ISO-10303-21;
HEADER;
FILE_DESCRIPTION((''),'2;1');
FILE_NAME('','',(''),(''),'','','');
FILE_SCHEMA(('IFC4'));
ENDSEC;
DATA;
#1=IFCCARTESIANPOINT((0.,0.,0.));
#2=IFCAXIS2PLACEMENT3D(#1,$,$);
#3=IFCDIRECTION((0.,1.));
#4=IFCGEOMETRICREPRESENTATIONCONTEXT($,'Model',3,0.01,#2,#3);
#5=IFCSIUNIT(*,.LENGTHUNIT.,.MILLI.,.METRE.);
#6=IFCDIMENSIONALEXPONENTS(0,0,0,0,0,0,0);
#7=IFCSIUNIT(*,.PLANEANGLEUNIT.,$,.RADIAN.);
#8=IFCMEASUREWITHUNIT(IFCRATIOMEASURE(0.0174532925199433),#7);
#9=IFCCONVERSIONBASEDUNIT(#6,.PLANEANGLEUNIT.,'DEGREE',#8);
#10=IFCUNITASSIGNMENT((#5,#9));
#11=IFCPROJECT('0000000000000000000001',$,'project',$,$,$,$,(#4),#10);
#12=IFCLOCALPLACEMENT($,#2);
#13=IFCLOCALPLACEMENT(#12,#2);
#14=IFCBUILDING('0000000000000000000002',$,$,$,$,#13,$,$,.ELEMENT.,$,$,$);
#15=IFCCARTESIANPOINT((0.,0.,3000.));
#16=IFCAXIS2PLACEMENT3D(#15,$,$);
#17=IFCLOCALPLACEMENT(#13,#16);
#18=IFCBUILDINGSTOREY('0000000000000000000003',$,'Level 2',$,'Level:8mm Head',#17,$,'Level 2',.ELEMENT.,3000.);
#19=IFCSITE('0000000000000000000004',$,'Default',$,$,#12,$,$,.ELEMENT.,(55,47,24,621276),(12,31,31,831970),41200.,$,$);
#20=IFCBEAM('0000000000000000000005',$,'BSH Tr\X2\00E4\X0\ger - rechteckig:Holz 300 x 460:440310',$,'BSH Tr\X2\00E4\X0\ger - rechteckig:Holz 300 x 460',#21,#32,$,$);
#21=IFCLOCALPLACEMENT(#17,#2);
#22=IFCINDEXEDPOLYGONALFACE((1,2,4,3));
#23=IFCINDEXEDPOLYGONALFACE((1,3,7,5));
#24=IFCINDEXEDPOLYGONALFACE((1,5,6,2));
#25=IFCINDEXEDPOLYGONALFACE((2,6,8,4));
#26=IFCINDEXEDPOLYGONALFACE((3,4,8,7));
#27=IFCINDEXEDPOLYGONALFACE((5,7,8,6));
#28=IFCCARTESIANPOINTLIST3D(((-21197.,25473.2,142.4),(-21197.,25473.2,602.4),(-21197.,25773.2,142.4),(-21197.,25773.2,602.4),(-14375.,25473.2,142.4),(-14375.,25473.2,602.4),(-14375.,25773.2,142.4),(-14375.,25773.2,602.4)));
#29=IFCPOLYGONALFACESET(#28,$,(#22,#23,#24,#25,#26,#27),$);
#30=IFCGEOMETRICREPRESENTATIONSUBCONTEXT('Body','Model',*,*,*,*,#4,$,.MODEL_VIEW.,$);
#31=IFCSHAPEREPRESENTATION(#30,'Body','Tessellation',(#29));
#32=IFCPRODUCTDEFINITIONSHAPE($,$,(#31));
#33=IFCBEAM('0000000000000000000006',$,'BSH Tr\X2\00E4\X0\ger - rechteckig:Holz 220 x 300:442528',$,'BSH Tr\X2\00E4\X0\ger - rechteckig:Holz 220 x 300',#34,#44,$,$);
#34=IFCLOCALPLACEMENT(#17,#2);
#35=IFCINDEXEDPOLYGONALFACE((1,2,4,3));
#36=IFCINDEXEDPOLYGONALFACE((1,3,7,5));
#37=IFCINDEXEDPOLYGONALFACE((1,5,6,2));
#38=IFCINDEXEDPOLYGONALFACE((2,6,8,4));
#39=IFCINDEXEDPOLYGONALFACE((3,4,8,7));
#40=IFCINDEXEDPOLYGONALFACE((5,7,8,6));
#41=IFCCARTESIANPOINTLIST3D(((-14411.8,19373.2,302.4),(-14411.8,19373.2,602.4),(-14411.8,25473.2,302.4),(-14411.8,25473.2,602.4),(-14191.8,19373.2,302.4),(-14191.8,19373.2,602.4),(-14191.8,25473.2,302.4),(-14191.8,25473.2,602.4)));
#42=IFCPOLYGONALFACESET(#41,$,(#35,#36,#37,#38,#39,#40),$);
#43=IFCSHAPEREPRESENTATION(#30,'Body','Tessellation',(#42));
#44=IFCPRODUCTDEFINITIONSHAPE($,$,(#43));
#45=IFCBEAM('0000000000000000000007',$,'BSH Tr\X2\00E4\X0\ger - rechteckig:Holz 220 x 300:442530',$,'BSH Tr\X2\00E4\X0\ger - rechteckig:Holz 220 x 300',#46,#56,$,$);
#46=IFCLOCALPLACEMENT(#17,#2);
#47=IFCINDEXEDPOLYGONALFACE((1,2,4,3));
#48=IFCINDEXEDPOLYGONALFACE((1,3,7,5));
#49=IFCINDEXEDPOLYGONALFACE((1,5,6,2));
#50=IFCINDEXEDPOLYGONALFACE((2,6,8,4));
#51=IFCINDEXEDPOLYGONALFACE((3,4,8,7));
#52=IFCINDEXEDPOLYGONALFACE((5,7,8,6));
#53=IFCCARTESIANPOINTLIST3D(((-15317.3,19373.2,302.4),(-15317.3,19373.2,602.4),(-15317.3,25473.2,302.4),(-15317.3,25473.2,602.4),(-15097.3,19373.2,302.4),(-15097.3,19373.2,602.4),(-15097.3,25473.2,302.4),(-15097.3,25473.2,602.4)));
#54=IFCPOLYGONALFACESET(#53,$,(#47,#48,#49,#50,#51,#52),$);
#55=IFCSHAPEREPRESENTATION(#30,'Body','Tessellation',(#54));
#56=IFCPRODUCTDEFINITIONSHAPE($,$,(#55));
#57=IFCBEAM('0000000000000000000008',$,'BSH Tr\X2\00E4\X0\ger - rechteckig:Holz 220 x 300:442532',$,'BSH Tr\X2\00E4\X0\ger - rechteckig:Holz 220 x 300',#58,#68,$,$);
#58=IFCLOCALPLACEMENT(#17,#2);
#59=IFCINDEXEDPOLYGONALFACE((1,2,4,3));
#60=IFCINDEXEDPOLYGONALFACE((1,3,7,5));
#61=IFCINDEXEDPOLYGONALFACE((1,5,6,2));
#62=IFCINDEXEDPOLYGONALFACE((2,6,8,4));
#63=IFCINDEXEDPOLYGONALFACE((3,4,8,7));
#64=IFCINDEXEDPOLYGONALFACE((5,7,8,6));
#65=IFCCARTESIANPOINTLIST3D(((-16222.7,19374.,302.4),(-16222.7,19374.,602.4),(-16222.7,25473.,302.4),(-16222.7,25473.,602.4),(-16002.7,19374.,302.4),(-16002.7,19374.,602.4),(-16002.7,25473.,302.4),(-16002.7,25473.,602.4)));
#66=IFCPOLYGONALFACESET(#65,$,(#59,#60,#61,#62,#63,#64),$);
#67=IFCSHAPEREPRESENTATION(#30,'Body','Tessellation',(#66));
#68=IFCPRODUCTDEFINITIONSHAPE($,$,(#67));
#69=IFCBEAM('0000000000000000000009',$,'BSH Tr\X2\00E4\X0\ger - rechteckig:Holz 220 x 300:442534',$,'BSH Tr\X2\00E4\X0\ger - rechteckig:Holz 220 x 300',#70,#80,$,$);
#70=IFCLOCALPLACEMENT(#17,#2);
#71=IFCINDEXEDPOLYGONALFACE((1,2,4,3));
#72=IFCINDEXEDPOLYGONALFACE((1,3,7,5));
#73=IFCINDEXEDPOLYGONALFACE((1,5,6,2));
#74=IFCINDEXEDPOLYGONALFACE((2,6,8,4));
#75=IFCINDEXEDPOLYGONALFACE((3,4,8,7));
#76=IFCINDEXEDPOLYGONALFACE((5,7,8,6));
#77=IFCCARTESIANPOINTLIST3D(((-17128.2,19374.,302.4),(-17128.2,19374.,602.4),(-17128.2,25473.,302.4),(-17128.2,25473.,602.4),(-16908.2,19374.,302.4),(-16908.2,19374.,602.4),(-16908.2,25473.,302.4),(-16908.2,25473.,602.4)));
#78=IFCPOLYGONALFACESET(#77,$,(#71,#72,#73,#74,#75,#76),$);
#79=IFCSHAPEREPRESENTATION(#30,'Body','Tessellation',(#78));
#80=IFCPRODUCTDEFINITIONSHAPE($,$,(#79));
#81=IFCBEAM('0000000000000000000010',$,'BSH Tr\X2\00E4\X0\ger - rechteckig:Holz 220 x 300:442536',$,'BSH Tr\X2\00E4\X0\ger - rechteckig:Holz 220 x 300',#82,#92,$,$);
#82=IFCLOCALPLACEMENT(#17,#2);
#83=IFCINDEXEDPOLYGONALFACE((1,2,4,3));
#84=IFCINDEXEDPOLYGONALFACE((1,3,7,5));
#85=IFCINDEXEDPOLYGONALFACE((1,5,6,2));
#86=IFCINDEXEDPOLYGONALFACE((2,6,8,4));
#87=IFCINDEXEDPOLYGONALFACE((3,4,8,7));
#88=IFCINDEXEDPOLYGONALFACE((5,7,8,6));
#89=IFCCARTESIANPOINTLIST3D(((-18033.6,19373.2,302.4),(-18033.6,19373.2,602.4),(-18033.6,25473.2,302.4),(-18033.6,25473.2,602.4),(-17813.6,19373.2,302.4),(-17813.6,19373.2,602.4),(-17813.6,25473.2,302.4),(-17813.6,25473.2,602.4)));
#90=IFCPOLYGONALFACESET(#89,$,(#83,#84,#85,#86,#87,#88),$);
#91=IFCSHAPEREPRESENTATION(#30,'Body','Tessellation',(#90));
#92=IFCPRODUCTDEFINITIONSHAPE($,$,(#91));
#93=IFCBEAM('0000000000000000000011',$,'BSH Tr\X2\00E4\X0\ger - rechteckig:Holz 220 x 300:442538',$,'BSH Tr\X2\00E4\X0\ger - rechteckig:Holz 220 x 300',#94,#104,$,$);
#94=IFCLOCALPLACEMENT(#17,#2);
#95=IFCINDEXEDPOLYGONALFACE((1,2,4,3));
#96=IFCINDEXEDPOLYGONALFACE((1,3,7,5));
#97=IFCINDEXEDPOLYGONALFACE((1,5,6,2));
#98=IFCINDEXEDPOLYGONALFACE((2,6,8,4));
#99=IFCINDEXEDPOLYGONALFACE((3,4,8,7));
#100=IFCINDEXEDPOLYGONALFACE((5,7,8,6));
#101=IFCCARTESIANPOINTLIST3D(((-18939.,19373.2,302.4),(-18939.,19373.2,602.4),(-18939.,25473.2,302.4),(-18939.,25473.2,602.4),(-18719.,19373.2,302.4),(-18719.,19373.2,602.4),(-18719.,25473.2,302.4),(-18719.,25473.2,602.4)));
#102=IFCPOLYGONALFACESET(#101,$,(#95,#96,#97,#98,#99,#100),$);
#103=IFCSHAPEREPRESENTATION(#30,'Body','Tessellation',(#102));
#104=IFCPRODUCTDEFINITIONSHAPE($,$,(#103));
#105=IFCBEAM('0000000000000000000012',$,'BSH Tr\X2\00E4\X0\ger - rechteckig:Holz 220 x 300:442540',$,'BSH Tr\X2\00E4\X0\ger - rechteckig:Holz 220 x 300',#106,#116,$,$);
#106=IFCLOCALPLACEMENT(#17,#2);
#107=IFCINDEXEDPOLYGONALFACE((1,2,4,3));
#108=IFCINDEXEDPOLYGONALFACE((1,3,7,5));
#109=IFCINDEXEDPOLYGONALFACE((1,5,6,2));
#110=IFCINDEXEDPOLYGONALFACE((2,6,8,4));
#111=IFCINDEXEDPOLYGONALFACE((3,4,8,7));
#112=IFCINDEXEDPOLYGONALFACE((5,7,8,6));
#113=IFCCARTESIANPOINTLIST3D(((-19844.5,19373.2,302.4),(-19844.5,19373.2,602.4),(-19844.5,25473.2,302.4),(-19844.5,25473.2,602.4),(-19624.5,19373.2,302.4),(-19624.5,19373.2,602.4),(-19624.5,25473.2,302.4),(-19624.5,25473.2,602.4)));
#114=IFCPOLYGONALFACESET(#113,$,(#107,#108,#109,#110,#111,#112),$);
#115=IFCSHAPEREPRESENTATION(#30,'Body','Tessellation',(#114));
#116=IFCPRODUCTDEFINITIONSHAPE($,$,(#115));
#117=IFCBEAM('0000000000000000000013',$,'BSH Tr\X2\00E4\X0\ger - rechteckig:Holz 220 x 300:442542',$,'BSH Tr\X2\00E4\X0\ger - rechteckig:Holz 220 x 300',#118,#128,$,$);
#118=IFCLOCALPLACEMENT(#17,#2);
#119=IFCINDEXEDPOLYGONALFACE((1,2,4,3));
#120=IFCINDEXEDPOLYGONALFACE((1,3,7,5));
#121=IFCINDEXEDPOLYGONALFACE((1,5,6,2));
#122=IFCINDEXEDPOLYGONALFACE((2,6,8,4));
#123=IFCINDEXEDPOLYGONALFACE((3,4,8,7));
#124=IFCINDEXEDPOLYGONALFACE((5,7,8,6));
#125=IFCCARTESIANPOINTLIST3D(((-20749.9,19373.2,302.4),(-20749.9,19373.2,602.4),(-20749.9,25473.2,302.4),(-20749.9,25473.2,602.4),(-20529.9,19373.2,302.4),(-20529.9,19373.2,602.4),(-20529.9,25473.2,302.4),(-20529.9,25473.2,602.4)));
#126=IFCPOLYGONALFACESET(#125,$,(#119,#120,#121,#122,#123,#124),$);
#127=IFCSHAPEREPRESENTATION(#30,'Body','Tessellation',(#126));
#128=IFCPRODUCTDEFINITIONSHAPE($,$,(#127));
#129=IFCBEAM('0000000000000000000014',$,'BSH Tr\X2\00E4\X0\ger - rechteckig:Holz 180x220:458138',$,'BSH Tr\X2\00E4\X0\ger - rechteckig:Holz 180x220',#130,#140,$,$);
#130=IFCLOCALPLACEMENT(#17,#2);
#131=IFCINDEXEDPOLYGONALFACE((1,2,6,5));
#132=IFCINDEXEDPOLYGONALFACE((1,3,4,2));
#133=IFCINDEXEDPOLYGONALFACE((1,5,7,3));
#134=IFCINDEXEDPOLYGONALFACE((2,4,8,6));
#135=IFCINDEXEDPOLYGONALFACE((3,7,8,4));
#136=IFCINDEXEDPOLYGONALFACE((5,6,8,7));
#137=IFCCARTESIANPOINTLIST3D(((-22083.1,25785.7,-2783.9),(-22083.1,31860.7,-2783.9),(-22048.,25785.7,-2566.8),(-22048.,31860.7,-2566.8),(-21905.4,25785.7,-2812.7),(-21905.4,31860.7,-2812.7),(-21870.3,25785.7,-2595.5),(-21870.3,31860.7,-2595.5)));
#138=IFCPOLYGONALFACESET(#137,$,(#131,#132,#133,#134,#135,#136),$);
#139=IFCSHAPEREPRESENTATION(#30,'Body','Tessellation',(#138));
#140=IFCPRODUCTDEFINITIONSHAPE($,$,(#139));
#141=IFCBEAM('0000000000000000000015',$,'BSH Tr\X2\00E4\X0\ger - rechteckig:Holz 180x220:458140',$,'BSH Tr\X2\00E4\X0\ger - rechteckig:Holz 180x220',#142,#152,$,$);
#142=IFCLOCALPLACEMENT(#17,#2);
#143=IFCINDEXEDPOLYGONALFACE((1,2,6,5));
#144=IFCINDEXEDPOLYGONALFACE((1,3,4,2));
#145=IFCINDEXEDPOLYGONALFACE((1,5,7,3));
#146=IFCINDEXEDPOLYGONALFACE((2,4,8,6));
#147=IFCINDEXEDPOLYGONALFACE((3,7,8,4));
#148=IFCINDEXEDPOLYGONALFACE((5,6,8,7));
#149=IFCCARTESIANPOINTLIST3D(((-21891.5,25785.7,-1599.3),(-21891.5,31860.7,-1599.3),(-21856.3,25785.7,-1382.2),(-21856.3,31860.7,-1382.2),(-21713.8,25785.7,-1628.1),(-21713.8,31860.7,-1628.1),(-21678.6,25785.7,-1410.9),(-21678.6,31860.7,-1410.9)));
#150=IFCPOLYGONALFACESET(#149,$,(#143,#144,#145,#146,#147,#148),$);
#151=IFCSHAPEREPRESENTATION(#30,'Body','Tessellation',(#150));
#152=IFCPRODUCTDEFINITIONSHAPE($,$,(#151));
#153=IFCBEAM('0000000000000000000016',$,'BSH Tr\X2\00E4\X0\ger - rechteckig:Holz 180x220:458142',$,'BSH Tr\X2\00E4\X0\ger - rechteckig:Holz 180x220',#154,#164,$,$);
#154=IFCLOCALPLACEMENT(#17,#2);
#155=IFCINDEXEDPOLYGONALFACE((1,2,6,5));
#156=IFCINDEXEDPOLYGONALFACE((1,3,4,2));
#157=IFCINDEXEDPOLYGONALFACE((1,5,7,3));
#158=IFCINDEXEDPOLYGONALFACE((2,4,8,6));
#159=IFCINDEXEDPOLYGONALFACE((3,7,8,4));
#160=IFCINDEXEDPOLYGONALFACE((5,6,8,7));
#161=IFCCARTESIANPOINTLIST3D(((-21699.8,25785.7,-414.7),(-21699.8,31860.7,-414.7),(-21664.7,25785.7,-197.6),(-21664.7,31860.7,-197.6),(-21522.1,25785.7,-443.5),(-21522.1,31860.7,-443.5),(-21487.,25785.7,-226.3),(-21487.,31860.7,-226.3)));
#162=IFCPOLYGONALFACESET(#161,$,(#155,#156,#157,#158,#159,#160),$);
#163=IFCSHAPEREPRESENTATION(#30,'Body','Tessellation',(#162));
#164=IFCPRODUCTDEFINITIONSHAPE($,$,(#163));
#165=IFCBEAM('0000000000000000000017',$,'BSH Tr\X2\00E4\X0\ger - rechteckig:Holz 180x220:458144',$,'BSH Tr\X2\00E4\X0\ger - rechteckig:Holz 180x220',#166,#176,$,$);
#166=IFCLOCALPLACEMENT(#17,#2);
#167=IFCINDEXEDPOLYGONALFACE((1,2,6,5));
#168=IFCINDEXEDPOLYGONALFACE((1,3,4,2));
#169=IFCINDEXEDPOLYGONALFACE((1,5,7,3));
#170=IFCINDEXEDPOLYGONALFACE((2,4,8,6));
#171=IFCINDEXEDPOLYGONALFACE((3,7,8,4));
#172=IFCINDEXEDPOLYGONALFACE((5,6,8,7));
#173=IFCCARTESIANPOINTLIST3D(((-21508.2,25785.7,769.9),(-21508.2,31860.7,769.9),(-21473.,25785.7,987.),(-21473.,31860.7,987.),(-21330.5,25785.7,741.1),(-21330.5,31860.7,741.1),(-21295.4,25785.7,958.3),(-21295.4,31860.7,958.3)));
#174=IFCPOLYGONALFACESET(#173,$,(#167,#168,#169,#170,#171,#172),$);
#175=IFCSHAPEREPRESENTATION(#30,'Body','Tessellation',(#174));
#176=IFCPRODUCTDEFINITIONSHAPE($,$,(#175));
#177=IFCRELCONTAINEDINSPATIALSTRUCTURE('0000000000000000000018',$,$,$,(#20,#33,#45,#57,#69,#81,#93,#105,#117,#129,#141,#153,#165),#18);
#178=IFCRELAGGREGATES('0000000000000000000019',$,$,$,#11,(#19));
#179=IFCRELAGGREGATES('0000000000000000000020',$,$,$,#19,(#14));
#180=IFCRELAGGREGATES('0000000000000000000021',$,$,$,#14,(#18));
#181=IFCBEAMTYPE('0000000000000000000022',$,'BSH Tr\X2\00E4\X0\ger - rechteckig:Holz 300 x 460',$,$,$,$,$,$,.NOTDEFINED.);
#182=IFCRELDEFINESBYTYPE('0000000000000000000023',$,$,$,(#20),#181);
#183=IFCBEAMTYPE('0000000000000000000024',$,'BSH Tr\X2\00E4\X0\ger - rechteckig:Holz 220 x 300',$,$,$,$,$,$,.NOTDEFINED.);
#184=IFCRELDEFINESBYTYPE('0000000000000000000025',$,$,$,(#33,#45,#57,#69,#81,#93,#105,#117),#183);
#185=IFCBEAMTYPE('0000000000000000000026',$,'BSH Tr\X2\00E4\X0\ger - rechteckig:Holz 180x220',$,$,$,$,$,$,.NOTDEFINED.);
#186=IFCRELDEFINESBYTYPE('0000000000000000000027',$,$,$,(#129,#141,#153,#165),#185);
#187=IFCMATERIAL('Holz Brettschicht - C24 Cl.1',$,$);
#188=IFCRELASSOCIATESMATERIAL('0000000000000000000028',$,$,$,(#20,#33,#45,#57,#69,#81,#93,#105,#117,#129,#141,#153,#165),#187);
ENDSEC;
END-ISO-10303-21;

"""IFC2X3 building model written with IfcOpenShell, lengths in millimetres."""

from ifc_helpers import new_model, entity, si_unit, converted_unit, direction, frame, frame_2d, origin, origin_2d_with_axis, place, context, subcontext, project, spatial, rectangle, extrude, material, type_object, element, save


model = new_model("IFC2X3")

# Units and contexts
model_context = context("Model", 3, precision=0.01, world=origin(), true_north=direction((0.0, 1.0)))
body_context = subcontext(model_context, "Body", "Model", "MODEL_VIEW")
ifc_project = project(units=[si_unit("LENGTHUNIT", "METRE", prefix="MILLI"), converted_unit("PLANEANGLEUNIT", "DEGREE", entity("IfcRatioMeasure", 0.0174532925199433), si_unit("PLANEANGLEUNIT", "RADIAN"), dimensions=[0, 0, 0, 0, 0, 0, 0])], contexts=[model_context])

# Site, building, storey
site_placement = place(None, origin())
site = spatial("IfcSite", under=ifc_project, at=site_placement, Name="Default", CompositionType="ELEMENT", RefLatitude=(55, 47, 24, 621276), RefLongitude=(12, 31, 31, 831970), RefElevation=41200.0)
building_placement = place(site_placement, origin())
building = spatial("IfcBuilding", under=site, at=building_placement, CompositionType="ELEMENT")
storey_placement = place(building_placement, frame((0.0, 0.0, 3000.0)))
storey = spatial("IfcBuildingStorey", under=building, at=storey_placement, Name="Level 2", ObjectType="Level:8mm Head", LongName="Level 2", CompositionType="ELEMENT", Elevation=3000.0)

# Beams
ifc_material_1 = material(Name="Holz Brettschicht - C24 Cl.1")
beam_type_1 = type_object("IfcBeamType", Name="BSH Träger - rechteckig:Holz 300 x 460", PredefinedType="NOTDEFINED")
beam_1_placement = place(storey_placement, frame((-14041.8, 25623.2, 602.4), z_axis=(0.0, 0.0, 1.0), x_axis=(-1.0, 0.0, 0.0)))
element("IfcBeam", 1, at=beam_1_placement, inside=storey, type_object=beam_type_1, material=ifc_material_1, Name="BSH Träger - rechteckig:Holz 300 x 460:440310", ObjectType="BSH Träger - rechteckig:Holz 300 x 460", context=body_context, shape_type="SweptSolid", body=[
    extrude(rectangle(XDim=460.0, YDim=300.0, at=frame_2d((0.0, 0.0), x_axis=(1.0, 0.0))), frame((333.2, 0.0, -230.0), z_axis=(1.0, 0.0, 0.0), x_axis=(0.0, 0.0, -1.0)), (0.0, 0.0, 1.0), 6822.0),
])
beam_type_2 = type_object("IfcBeamType", Name="BSH Träger - rechteckig:Holz 220 x 300", PredefinedType="NOTDEFINED")
for number, where, z_axis, x_axis, name in (
    (2, (-14301.8, 25623.2, 602.4), (0.0, 0.0, 1.0), (0.0, -1.0, 0.0), "BSH Träger - rechteckig:Holz 220 x 300:442528"),
    (3, (-15207.3, 25623.2, 602.4), (0.0, 0.0, 1.0), (0.0, -1.0, 0.0), "BSH Träger - rechteckig:Holz 220 x 300:442530"),
):
    element("IfcBeam", number, at=place(storey_placement, frame(where, z_axis=z_axis, x_axis=x_axis)), inside=storey, type_object=beam_type_2, material=ifc_material_1, Name=name, ObjectType="BSH Träger - rechteckig:Holz 220 x 300", context=body_context, shape_type="SweptSolid", body=[
        extrude(rectangle(XDim=300.0, YDim=220.0, at=frame_2d((0.0, 0.0), x_axis=(1.0, 0.0))), frame((150.0, 0.0, -150.0), z_axis=(1.0, 0.0, 0.0), x_axis=(0.0, 0.0, -1.0)), (0.0, 0.0, 1.0), 6100.0),
    ])
for number, where, z_axis, x_axis, name in (
    (4, (-16112.7, 25536.0, 602.4), (0.0, 0.0, 1.0), (0.0, -1.0, 0.0), "BSH Träger - rechteckig:Holz 220 x 300:442532"),
    (5, (-17018.2, 25536.0, 602.4), (0.0, 0.0, 1.0), (0.0, -1.0, 0.0), "BSH Träger - rechteckig:Holz 220 x 300:442534"),
):
    element("IfcBeam", number, at=place(storey_placement, frame(where, z_axis=z_axis, x_axis=x_axis)), inside=storey, type_object=beam_type_2, material=ifc_material_1, Name=name, ObjectType="BSH Träger - rechteckig:Holz 220 x 300", context=body_context, shape_type="SweptSolid", body=[
        extrude(rectangle(XDim=300.0, YDim=220.0, at=frame_2d((0.0, 0.0), x_axis=(1.0, 0.0))), frame((63.0, 0.0, -150.0), z_axis=(1.0, 0.0, 0.0), x_axis=(0.0, 0.0, -1.0)), (0.0, 0.0, 1.0), 6099.0),
    ])
for number, where, z_axis, x_axis, name in (
    (6, (-17923.6, 25623.2, 602.4), (0.0, 0.0, 1.0), (0.0, -1.0, 0.0), "BSH Träger - rechteckig:Holz 220 x 300:442536"),
    (7, (-18829.0, 25623.2, 602.4), (0.0, 0.0, 1.0), (0.0, -1.0, 0.0), "BSH Träger - rechteckig:Holz 220 x 300:442538"),
):
    element("IfcBeam", number, at=place(storey_placement, frame(where, z_axis=z_axis, x_axis=x_axis)), inside=storey, type_object=beam_type_2, material=ifc_material_1, Name=name, ObjectType="BSH Träger - rechteckig:Holz 220 x 300", context=body_context, shape_type="SweptSolid", body=[
        extrude(rectangle(XDim=300.0, YDim=220.0, at=frame_2d((0.0, 0.0), x_axis=(1.0, 0.0))), frame((150.0, 0.0, -150.0), z_axis=(1.0, 0.0, 0.0), x_axis=(0.0, 0.0, -1.0)), (0.0, 0.0, 1.0), 6100.0),
    ])
for number, where, z_axis, x_axis, name in (
    (8, (-19734.5, 25623.2, 602.4), (0.0, 0.0, 1.0), (0.0, -1.0, 0.0), "BSH Träger - rechteckig:Holz 220 x 300:442540"),
    (9, (-20639.9, 25623.2, 602.4), (0.0, 0.0, 1.0), (0.0, -1.0, 0.0), "BSH Träger - rechteckig:Holz 220 x 300:442542"),
):
    element("IfcBeam", number, at=place(storey_placement, frame(where, z_axis=z_axis, x_axis=x_axis)), inside=storey, type_object=beam_type_2, material=ifc_material_1, Name=name, ObjectType="BSH Träger - rechteckig:Holz 220 x 300", context=body_context, shape_type="SweptSolid", body=[
        extrude(rectangle(XDim=300.0, YDim=220.0, at=origin_2d_with_axis()), frame((150.0, 0.0, -150.0), z_axis=(1.0, 0.0, 0.0), x_axis=(0.0, 0.0, -1.0)), (0.0, 0.0, 1.0), 6100.0),
    ])
beam_type_3 = type_object("IfcBeamType", Name="BSH Träger - rechteckig:Holz 180x220", PredefinedType="NOTDEFINED")
beam_2_placement = place(storey_placement, frame((-22048.0, 31423.2, -2566.8), z_axis=(0.0, 0.0, 1.0), x_axis=(0.0, -1.0, 0.0)))
element("IfcBeam", 10, at=beam_2_placement, inside=storey, type_object=beam_type_3, material=ifc_material_1, Name="BSH Träger - rechteckig:Holz 180x220:458138", ObjectType="BSH Träger - rechteckig:Holz 180x220", context=body_context, shape_type="SweptSolid", body=[
    extrude(rectangle(XDim=220.0, YDim=180.0, at=frame_2d((0.0, 0.0), x_axis=(1.0, 0.0))), frame((-437.5, 71.3, -123.0), z_axis=(1.0, 0.0, 0.0), x_axis=(0.0, 0.159701, 0.987165)), (0.0, 0.0, 1.0), 6075.0),
])
beam_3_placement = place(storey_placement, frame((-21856.3, 31423.2, -1382.2), z_axis=(0.0, 0.0, 1.0), x_axis=(0.0, -1.0, 0.0)))
element("IfcBeam", 11, at=beam_3_placement, inside=storey, type_object=beam_type_3, material=ifc_material_1, Name="BSH Träger - rechteckig:Holz 180x220:458140", ObjectType="BSH Träger - rechteckig:Holz 180x220", context=body_context, shape_type="SweptSolid", body=[
    extrude(rectangle(XDim=220.0, YDim=180.0, at=frame_2d((0.0, 0.0), x_axis=(1.0, 0.0))), frame((-437.5, 71.3, -123.0), z_axis=(1.0, 0.0, 0.0), x_axis=(0.0, 0.159701, 0.987165)), (0.0, 0.0, 1.0), 6075.0),
])
beam_4_placement = place(storey_placement, frame((-21664.7, 31423.2, -197.6), z_axis=(0.0, 0.0, 1.0), x_axis=(0.0, -1.0, 0.0)))
element("IfcBeam", 12, at=beam_4_placement, inside=storey, type_object=beam_type_3, material=ifc_material_1, Name="BSH Träger - rechteckig:Holz 180x220:458142", ObjectType="BSH Träger - rechteckig:Holz 180x220", context=body_context, shape_type="SweptSolid", body=[
    extrude(rectangle(XDim=220.0, YDim=180.0, at=frame_2d((0.0, 0.0), x_axis=(1.0, 0.0))), frame((-437.5, 71.3, -123.0), z_axis=(1.0, 0.0, 0.0), x_axis=(0.0, 0.159701, 0.987165)), (0.0, 0.0, 1.0), 6075.0),
])
beam_5_placement = place(storey_placement, frame((-21473.0, 31423.2, 987.0), z_axis=(0.0, 0.0, 1.0), x_axis=(0.0, -1.0, 0.0)))
element("IfcBeam", 13, at=beam_5_placement, inside=storey, type_object=beam_type_3, material=ifc_material_1, Name="BSH Träger - rechteckig:Holz 180x220:458144", ObjectType="BSH Träger - rechteckig:Holz 180x220", context=body_context, shape_type="SweptSolid", body=[
    extrude(rectangle(XDim=220.0, YDim=180.0, at=frame_2d((0.0, 0.0), x_axis=(1.0, 0.0))), frame((-437.5, 71.3, -123.0), z_axis=(1.0, 0.0, 0.0), x_axis=(0.0, 0.159701, 0.987165)), (0.0, 0.0, 1.0), 6075.0),
])

save(model, "model.ifc")
